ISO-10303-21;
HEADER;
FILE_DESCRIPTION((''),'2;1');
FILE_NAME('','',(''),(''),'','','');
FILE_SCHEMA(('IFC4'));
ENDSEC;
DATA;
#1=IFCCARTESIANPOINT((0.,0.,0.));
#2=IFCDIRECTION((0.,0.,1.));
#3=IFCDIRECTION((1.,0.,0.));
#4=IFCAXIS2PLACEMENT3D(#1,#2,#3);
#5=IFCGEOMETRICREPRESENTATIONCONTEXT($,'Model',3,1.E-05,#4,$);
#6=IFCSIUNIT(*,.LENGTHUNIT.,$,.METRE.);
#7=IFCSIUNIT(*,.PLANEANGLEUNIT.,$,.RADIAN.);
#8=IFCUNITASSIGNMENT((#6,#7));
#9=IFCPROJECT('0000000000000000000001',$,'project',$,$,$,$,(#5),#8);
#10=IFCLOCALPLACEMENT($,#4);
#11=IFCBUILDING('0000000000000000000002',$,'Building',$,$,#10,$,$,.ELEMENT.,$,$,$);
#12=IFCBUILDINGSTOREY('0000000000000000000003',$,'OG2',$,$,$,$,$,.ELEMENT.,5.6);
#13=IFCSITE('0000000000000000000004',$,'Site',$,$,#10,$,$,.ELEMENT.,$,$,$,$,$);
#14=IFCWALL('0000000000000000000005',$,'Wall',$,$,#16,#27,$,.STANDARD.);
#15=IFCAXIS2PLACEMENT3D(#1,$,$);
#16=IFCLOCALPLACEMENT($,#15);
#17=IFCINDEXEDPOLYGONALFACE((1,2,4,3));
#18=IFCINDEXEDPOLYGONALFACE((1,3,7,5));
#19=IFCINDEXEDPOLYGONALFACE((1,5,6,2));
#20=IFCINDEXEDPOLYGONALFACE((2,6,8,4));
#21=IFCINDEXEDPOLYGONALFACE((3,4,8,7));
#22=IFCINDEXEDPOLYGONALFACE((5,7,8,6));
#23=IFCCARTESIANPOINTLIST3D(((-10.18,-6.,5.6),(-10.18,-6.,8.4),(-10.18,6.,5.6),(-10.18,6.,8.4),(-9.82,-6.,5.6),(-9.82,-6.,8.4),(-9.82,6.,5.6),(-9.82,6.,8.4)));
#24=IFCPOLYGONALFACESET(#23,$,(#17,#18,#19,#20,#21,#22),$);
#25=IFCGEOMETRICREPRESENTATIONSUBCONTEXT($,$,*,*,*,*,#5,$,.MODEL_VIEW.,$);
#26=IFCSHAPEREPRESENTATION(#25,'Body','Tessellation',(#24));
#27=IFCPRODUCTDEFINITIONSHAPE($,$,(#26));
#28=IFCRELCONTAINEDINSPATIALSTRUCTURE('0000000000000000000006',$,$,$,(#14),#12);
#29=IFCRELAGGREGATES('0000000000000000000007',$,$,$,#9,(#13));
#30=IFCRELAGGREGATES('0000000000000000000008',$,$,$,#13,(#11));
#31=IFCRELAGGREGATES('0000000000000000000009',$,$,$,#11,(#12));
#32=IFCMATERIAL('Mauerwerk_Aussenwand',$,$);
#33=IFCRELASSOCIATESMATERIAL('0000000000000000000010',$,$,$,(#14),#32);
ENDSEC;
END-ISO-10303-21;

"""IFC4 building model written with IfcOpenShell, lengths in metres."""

from ifc_helpers import new_model, si_unit, frame, frame_2d, origin, origin_with_axes, place, context, subcontext, project, spatial, rectangle, extrude, material, element, save


model = new_model("IFC4")

# Units and contexts
model_context = context("Model", 3, precision=1e-05, world=origin_with_axes())
sub_context = subcontext(model_context, None, None, "MODEL_VIEW")
ifc_project = project(units=[si_unit("LENGTHUNIT", "METRE"), si_unit("PLANEANGLEUNIT", "RADIAN")], contexts=[model_context])

# Site, building, storey
placement_1 = place(None, origin_with_axes())
site = spatial("IfcSite", under=ifc_project, at=placement_1, Name="Site", CompositionType="ELEMENT")
building = spatial("IfcBuilding", under=site, at=placement_1, Name="Building", CompositionType="ELEMENT")
storey = spatial("IfcBuildingStorey", under=building, Name="OG2", CompositionType="ELEMENT", Elevation=5.6)

# Wall
ifc_material = material(Name="Mauerwerk_Aussenwand")
placement_2 = place(None, origin_with_axes())
placement_3 = place(placement_2, frame((0.0, 0.0, 5.6)))
wall_placement = place(placement_3, frame((-10.0, -6.0, 0.0), x_axis=(0.0, 1.0, 0.0)))
element("IfcWall", 1, at=wall_placement, inside=storey, material=ifc_material, Name="Wall", PredefinedType="STANDARD", context=sub_context, shape_type="SweptSolid", body=[
    extrude(rectangle(XDim=12.0, YDim=0.36, at=frame_2d((6.0, 0.0))), origin(), (0.0, 0.0, 1.0), 2.8),
])

save(model, "model.ifc")
